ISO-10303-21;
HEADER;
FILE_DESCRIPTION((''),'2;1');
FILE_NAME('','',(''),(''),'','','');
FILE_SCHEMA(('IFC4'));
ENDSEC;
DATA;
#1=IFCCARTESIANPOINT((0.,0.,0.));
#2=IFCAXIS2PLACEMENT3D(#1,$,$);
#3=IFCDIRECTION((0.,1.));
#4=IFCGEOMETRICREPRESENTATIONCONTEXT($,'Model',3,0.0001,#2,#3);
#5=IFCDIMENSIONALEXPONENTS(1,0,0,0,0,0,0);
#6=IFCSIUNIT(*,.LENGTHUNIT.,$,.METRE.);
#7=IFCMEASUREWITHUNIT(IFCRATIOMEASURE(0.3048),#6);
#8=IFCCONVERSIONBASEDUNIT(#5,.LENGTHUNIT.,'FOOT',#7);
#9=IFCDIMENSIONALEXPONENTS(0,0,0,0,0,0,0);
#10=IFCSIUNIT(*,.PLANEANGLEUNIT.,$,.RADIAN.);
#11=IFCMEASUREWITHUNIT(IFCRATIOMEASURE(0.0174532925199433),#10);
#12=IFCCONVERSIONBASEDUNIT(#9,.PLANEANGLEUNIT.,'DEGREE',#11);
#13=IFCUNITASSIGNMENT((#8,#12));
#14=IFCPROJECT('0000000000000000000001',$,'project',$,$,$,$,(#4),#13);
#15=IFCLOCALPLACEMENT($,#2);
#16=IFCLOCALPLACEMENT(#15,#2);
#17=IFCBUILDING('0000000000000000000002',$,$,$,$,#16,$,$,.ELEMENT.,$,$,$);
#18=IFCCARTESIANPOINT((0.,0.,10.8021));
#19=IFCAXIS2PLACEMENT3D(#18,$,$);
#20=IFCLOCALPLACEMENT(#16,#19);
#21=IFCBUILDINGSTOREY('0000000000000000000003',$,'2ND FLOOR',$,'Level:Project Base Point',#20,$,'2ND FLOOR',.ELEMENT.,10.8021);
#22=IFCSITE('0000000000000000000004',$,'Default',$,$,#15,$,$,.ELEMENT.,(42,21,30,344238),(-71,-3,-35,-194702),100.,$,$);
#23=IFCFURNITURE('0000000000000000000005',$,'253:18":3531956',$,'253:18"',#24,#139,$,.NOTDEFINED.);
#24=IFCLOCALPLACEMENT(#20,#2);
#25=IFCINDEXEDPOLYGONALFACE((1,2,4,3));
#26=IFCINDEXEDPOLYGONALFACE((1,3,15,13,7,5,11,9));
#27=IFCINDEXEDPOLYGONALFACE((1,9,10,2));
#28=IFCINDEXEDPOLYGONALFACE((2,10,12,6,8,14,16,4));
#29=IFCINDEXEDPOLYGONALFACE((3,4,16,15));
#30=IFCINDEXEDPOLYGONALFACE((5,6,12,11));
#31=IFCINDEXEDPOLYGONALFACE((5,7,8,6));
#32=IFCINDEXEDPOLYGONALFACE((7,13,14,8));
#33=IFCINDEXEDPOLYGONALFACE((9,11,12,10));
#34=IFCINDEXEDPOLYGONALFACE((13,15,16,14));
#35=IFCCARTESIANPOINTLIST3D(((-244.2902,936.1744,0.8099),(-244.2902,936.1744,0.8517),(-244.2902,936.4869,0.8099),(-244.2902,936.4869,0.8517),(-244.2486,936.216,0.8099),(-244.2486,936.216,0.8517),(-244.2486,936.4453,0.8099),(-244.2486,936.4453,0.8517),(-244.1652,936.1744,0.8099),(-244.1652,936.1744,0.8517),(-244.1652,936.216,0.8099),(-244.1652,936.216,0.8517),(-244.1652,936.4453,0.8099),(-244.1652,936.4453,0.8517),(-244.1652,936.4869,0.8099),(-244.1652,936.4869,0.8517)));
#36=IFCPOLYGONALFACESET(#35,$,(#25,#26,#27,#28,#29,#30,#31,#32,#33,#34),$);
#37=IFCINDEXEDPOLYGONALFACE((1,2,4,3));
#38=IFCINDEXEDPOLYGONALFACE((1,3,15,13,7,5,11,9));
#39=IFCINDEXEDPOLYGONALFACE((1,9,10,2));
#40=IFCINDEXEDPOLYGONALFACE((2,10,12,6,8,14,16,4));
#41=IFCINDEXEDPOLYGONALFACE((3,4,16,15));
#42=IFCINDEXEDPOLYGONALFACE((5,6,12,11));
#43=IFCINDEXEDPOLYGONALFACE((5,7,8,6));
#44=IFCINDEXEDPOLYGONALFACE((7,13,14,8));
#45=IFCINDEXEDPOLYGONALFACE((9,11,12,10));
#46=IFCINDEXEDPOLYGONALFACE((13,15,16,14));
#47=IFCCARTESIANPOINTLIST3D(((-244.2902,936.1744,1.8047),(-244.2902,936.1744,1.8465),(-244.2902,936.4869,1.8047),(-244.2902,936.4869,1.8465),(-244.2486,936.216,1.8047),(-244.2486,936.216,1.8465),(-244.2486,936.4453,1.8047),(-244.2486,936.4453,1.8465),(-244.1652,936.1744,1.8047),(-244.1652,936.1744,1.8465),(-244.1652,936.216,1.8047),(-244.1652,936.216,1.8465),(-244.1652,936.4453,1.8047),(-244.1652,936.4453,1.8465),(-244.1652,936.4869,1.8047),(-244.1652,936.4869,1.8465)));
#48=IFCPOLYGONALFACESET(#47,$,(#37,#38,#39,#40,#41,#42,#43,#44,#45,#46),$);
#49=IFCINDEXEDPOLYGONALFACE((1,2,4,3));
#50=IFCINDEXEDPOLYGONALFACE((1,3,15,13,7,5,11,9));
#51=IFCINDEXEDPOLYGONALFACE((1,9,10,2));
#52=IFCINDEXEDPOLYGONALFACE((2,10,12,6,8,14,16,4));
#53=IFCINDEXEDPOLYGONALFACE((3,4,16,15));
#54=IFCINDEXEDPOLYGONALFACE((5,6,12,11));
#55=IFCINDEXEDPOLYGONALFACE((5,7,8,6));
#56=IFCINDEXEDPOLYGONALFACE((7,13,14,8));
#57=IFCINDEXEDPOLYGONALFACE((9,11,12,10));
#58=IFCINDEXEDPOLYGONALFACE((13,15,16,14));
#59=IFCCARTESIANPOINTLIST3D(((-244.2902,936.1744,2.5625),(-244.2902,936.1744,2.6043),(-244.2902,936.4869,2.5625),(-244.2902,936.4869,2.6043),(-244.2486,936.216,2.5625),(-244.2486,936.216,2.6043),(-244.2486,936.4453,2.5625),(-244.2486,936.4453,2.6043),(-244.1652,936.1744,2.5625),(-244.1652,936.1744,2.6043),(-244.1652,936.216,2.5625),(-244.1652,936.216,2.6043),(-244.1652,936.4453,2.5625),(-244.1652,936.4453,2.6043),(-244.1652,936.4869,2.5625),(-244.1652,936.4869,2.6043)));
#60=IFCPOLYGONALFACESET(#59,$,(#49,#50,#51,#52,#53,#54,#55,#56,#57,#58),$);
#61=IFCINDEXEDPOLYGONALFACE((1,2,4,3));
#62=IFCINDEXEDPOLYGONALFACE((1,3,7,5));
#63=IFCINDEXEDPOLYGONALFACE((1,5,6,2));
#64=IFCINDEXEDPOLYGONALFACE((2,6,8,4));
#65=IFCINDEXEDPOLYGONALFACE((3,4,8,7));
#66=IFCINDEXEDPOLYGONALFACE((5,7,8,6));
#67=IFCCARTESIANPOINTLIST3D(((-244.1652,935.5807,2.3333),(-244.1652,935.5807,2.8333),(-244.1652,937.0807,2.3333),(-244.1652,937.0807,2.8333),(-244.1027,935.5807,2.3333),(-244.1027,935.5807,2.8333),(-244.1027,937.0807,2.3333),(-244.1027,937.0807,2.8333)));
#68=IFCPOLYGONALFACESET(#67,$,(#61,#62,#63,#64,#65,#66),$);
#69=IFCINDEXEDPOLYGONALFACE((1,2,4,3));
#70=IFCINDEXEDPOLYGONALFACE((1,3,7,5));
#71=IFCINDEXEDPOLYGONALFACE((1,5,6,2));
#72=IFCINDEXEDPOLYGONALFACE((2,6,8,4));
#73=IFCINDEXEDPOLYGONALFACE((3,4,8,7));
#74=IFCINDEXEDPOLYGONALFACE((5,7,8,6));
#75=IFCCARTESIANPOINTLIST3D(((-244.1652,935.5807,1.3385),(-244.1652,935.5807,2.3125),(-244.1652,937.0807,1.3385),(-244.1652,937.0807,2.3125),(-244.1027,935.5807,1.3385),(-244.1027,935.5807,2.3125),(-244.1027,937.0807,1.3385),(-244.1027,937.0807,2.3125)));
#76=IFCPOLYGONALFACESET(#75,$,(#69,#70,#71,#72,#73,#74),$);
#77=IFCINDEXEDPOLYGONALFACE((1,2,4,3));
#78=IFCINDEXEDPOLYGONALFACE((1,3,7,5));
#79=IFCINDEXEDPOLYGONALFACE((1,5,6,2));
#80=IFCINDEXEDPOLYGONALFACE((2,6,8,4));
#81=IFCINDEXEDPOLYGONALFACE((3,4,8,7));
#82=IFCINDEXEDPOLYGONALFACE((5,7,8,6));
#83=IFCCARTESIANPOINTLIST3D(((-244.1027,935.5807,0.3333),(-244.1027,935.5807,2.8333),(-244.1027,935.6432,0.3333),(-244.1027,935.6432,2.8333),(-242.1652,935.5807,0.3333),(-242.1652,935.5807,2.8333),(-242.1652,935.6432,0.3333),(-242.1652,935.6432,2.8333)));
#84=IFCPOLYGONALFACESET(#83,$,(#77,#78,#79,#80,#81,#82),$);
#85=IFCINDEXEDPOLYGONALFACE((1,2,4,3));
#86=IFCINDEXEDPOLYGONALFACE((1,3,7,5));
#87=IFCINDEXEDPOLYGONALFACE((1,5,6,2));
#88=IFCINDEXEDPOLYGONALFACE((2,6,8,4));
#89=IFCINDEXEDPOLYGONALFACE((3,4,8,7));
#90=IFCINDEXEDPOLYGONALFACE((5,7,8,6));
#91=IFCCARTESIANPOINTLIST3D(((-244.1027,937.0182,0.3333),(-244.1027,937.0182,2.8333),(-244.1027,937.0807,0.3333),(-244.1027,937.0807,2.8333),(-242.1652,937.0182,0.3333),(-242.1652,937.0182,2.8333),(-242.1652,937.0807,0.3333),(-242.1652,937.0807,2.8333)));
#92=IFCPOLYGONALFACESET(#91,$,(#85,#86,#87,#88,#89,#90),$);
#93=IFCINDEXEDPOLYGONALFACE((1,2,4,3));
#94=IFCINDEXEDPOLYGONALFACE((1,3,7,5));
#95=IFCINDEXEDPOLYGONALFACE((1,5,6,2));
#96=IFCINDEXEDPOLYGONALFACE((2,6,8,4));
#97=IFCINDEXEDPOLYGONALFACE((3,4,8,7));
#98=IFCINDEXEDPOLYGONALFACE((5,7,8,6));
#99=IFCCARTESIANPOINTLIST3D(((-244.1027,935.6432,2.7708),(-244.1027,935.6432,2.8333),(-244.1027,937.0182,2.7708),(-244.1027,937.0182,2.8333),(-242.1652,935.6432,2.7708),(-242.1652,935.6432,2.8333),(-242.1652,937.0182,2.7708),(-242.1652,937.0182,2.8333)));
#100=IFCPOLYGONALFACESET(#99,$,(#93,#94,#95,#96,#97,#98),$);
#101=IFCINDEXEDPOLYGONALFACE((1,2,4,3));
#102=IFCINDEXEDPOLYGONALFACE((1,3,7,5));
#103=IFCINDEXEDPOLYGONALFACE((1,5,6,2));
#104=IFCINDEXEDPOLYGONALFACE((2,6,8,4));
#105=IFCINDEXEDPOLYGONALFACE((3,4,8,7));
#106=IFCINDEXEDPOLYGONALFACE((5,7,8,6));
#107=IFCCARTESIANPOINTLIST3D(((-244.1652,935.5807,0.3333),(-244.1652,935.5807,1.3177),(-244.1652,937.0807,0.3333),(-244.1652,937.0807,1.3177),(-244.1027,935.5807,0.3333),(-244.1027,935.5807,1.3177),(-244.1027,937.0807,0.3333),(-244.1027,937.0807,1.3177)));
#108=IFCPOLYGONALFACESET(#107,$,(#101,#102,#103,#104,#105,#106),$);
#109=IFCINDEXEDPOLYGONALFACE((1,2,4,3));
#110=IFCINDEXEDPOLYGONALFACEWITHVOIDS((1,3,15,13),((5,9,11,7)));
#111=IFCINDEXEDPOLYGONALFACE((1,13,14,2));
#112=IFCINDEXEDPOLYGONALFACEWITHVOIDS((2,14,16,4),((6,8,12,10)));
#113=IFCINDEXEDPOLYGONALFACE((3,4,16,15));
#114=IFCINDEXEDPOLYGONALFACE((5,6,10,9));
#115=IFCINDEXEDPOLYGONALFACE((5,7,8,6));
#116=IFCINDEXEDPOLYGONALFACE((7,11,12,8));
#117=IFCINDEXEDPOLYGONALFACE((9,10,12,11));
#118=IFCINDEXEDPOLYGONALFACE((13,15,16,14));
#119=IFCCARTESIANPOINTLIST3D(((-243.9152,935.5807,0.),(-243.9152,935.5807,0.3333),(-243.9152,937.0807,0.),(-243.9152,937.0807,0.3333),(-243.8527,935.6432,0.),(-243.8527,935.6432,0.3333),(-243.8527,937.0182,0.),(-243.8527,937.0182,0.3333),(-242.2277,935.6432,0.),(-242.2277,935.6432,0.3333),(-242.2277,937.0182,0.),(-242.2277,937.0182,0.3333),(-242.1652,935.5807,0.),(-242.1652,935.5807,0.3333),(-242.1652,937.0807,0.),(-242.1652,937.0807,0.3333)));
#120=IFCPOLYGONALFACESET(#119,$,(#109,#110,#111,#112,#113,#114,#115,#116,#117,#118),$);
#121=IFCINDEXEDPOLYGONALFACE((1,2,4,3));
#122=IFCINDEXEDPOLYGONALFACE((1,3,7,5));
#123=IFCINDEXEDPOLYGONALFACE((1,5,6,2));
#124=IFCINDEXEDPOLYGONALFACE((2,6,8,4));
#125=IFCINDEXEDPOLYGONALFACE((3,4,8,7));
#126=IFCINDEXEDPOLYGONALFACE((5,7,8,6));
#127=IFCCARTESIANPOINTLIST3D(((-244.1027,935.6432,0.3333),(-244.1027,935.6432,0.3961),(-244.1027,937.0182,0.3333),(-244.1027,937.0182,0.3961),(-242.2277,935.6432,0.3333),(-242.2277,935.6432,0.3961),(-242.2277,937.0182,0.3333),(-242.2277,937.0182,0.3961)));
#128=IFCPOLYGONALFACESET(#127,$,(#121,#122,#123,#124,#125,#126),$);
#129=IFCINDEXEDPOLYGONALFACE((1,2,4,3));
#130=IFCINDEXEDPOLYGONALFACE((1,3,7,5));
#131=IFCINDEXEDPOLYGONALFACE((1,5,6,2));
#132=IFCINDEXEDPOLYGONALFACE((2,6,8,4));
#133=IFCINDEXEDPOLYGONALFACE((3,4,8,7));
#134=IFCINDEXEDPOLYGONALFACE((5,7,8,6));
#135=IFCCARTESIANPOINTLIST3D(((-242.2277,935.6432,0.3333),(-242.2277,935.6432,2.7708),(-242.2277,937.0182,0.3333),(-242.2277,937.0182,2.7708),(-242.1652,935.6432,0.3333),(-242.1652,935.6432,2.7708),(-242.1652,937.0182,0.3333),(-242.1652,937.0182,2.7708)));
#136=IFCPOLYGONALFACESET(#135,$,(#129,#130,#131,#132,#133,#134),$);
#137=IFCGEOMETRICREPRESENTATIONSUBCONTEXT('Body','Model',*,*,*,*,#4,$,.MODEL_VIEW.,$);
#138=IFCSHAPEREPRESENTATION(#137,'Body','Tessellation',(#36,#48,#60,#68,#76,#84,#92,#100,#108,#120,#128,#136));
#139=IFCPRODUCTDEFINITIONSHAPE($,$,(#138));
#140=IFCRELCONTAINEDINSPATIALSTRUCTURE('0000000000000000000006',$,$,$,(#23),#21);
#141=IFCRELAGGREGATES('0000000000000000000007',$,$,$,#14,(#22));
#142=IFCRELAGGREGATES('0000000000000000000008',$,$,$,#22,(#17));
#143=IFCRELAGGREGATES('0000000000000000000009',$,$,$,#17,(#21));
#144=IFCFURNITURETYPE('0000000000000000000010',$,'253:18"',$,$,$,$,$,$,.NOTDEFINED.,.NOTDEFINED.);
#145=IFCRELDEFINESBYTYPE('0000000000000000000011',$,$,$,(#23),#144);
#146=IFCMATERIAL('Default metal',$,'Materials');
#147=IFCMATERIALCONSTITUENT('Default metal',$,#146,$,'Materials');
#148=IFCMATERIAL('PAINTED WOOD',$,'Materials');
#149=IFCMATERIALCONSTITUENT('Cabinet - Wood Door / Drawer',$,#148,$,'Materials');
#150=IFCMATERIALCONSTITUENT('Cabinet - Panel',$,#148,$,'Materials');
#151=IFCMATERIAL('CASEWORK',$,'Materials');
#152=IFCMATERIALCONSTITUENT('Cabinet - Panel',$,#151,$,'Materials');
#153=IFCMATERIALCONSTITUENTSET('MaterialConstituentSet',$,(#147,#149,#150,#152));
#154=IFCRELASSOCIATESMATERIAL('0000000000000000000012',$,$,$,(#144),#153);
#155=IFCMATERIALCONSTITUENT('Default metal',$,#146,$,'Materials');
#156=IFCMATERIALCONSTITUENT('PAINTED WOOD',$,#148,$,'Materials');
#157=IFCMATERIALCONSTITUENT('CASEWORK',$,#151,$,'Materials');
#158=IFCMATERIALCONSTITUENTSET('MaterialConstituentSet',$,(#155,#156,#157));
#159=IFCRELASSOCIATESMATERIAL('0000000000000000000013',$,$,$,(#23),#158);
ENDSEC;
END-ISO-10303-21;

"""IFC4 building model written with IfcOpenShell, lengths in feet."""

from ifc_helpers import new_model, entity, si_unit, converted_unit, direction, frame, frame_2d, origin, origin_2d_with_axis, place, context, subcontext, project, spatial, polyline, rectangle, outline, extrude, source, transform, mapped, material, constituent, constituent_set, type_object, type_shapes, element, save


model = new_model("IFC4")

# Units and contexts
model_context = context("Model", 3, precision=0.0001, world=origin(), true_north=direction((0.0, 1.0)))
body_context = subcontext(model_context, "Body", "Model", "MODEL_VIEW")
ifc_project = project(units=[converted_unit("LENGTHUNIT", "FOOT", entity("IfcRatioMeasure", 0.3048), si_unit("LENGTHUNIT", "METRE"), dimensions=[1, 0, 0, 0, 0, 0, 0]), converted_unit("PLANEANGLEUNIT", "DEGREE", entity("IfcRatioMeasure", 0.0174532925199433), si_unit("PLANEANGLEUNIT", "RADIAN"), dimensions=[0, 0, 0, 0, 0, 0, 0])], contexts=[model_context])

# Site, building, storey
site_placement = place(None, origin())
site = spatial("IfcSite", under=ifc_project, at=site_placement, Name="Default", CompositionType="ELEMENT", RefLatitude=(42, 21, 30, 344238), RefLongitude=(-71, -3, -35, -194702), RefElevation=100.0)
building_placement = place(site_placement, origin())
building = spatial("IfcBuilding", under=site, at=building_placement, CompositionType="ELEMENT")
storey_placement = place(building_placement, frame((0.0, 0.0, 10.8021)))
storey = spatial("IfcBuildingStorey", under=building, at=storey_placement, Name="2ND FLOOR", ObjectType="Level:Project Base Point", LongName="2ND FLOOR", CompositionType="ELEMENT", Elevation=10.8021)

# Furniture
ifc_material_1 = material(Name="CASEWORK", Category="Materials")
ifc_material_2 = material(Name="PAINTED WOOD", Category="Materials")
ifc_material_3 = material(Name="Default metal", Category="Materials")
ifc_constituent_1 = constituent(ifc_material_3, Name="Default metal", Category="Materials")
ifc_constituent_2 = constituent(ifc_material_2, Name="PAINTED WOOD", Category="Materials")
ifc_constituent_3 = constituent(ifc_material_1, Name="CASEWORK", Category="Materials")
ifc_constituent_set_1 = constituent_set(constituents=[ifc_constituent_1, ifc_constituent_2, ifc_constituent_3], Name="MaterialConstituentSet")
ifc_constituent_4 = constituent(ifc_material_3, Name="Default metal", Category="Materials")
ifc_constituent_5 = constituent(ifc_material_2, Name="Cabinet - Wood Door / Drawer", Category="Materials")
ifc_constituent_6 = constituent(ifc_material_2, Name="Cabinet - Panel", Category="Materials")
ifc_constituent_7 = constituent(ifc_material_1, Name="Cabinet - Panel", Category="Materials")
ifc_constituent_set_2 = constituent_set(constituents=[ifc_constituent_4, ifc_constituent_5, ifc_constituent_6, ifc_constituent_7], Name="MaterialConstituentSet")
furniture_type_1 = type_object("IfcFurnitureType", Name="253:18\"", AssemblyPlace="NOTDEFINED", PredefinedType="NOTDEFINED", material=ifc_constituent_set_2)
shared_shape_1 = source(origin(), body_context, "Body", "SweptSolid", [
    extrude(outline(polyline([(-0.1562, -0.0521), (-0.1146, -0.0521), (-0.1146, 0.0313), (0.1146, 0.0313), (0.1146, -0.0521), (0.1562, -0.0521), (0.1562, 0.0729), (-0.1562, 0.0729), (-0.1562, -0.0521)])), frame((0.0615, 2.0521, 0.8099)), (0.0, 0.0, 1.0), 0.0418),
    extrude(outline(polyline([(-0.1562, -0.0521), (-0.1146, -0.0521), (-0.1146, 0.0313), (0.1146, 0.0313), (0.1146, -0.0521), (0.1562, -0.0521), (0.1562, 0.0729), (-0.1562, 0.0729), (-0.1562, -0.0521)])), frame((0.0615, 2.0521, 1.8047)), (0.0, 0.0, 1.0), 0.0418),
    extrude(outline(polyline([(-0.1562, -0.0521), (-0.1146, -0.0521), (-0.1146, 0.0313), (0.1146, 0.0313), (0.1146, -0.0521), (0.1562, -0.0521), (0.1562, 0.0729), (-0.1562, 0.0729), (-0.1562, -0.0521)])), frame((0.0615, 2.0521, 2.5625)), (0.0, 0.0, 1.0), 0.0418),
    extrude(rectangle(XDim=1.5, YDim=0.0625, at=frame_2d((0.0, 0.0), x_axis=(1.0, 0.0))), frame((0.0615, 1.9688, 2.3333), z_axis=(0.0, 0.0, 1.0), x_axis=(-1.0, 0.0, 0.0)), (0.0, 0.0, 1.0), 0.5),
    extrude(rectangle(XDim=1.5, YDim=0.0625, at=frame_2d((0.0, 0.0), x_axis=(1.0, 0.0))), frame((0.0615, 1.9688, 1.3385), z_axis=(0.0, 0.0, 1.0), x_axis=(-1.0, 0.0, 0.0)), (0.0, 0.0, 1.0), 0.974),
    extrude(rectangle(XDim=1.9375, YDim=0.0625, at=frame_2d((0.0, 0.0), x_axis=(1.0, 0.0))), frame((-0.6573, 0.9687, 0.3333), z_axis=(0.0, 0.0, 1.0), x_axis=(0.0, -1.0, 0.0)), (0.0, 0.0, 1.0), 2.5),
    extrude(rectangle(XDim=1.9375, YDim=0.0625, at=frame_2d((0.0, 0.0), x_axis=(1.0, 0.0))), frame((0.7802, 0.9687, 0.3333), z_axis=(0.0, 0.0, 1.0), x_axis=(0.0, -1.0, 0.0)), (0.0, 0.0, 1.0), 2.5),
    extrude(rectangle(XDim=1.9375, YDim=1.375, at=origin_2d_with_axis()), frame((0.0615, 0.9688, 2.7708), z_axis=(0.0, 0.0, 1.0), x_axis=(0.0, 1.0, 0.0)), (0.0, 0.0, 1.0), 0.0625),
    extrude(rectangle(XDim=1.5, YDim=0.0625, at=frame_2d((0.0, 0.0), x_axis=(1.0, 0.0))), frame((0.0615, 1.9688, 0.3333), z_axis=(0.0, 0.0, 1.0), x_axis=(-1.0, 0.0, 0.0)), (0.0, 0.0, 1.0), 0.9844),
    extrude(outline(polyline([(-0.875, -0.75), (0.875, -0.75), (0.875, 0.75), (-0.875, 0.75), (-0.875, -0.75)]), holes=[polyline([(-0.8125, -0.6875), (-0.8125, 0.6875), (0.8125, 0.6875), (0.8125, -0.6875), (-0.8125, -0.6875)])]), frame((0.0615, 0.875, 0.0), z_axis=(0.0, 0.0, 1.0), x_axis=(0.0, -1.0, 0.0)), (0.0, 0.0, 1.0), 0.3333),
    extrude(rectangle(XDim=1.875, YDim=1.375, at=origin_2d_with_axis()), frame((0.0615, 1.0, 0.3333), z_axis=(0.0, 0.0, 1.0), x_axis=(0.0, 1.0, 0.0)), (0.0, 0.0, 1.0), 0.0627),
    extrude(rectangle(XDim=1.375, YDim=0.0625, at=origin_2d_with_axis()), frame((0.0615, 0.0312, 0.3333), z_axis=(0.0, 0.0, 1.0), x_axis=(-1.0, 0.0, 0.0)), (0.0, 0.0, 1.0), 2.4375),
])
type_shapes(furniture_type_1, [shared_shape_1])
furniture_1_placement = place(storey_placement, frame((-242.1652, 936.2692, 0.0), z_axis=(0.0, 0.0, 1.0), x_axis=(0.0, 1.0, 0.0)))
element("IfcFurniture", 1, at=furniture_1_placement, inside=storey, type_object=furniture_type_1, material=ifc_constituent_set_1, Name="253:18\":3531956", ObjectType="253:18\"", PredefinedType="NOTDEFINED", context=body_context, shape_type="MappedRepresentation", body=[
    mapped(shared_shape_1, transform((0.0, 0.0, 0.0), scale=1.0)),
])

save(model, "model.ifc")
